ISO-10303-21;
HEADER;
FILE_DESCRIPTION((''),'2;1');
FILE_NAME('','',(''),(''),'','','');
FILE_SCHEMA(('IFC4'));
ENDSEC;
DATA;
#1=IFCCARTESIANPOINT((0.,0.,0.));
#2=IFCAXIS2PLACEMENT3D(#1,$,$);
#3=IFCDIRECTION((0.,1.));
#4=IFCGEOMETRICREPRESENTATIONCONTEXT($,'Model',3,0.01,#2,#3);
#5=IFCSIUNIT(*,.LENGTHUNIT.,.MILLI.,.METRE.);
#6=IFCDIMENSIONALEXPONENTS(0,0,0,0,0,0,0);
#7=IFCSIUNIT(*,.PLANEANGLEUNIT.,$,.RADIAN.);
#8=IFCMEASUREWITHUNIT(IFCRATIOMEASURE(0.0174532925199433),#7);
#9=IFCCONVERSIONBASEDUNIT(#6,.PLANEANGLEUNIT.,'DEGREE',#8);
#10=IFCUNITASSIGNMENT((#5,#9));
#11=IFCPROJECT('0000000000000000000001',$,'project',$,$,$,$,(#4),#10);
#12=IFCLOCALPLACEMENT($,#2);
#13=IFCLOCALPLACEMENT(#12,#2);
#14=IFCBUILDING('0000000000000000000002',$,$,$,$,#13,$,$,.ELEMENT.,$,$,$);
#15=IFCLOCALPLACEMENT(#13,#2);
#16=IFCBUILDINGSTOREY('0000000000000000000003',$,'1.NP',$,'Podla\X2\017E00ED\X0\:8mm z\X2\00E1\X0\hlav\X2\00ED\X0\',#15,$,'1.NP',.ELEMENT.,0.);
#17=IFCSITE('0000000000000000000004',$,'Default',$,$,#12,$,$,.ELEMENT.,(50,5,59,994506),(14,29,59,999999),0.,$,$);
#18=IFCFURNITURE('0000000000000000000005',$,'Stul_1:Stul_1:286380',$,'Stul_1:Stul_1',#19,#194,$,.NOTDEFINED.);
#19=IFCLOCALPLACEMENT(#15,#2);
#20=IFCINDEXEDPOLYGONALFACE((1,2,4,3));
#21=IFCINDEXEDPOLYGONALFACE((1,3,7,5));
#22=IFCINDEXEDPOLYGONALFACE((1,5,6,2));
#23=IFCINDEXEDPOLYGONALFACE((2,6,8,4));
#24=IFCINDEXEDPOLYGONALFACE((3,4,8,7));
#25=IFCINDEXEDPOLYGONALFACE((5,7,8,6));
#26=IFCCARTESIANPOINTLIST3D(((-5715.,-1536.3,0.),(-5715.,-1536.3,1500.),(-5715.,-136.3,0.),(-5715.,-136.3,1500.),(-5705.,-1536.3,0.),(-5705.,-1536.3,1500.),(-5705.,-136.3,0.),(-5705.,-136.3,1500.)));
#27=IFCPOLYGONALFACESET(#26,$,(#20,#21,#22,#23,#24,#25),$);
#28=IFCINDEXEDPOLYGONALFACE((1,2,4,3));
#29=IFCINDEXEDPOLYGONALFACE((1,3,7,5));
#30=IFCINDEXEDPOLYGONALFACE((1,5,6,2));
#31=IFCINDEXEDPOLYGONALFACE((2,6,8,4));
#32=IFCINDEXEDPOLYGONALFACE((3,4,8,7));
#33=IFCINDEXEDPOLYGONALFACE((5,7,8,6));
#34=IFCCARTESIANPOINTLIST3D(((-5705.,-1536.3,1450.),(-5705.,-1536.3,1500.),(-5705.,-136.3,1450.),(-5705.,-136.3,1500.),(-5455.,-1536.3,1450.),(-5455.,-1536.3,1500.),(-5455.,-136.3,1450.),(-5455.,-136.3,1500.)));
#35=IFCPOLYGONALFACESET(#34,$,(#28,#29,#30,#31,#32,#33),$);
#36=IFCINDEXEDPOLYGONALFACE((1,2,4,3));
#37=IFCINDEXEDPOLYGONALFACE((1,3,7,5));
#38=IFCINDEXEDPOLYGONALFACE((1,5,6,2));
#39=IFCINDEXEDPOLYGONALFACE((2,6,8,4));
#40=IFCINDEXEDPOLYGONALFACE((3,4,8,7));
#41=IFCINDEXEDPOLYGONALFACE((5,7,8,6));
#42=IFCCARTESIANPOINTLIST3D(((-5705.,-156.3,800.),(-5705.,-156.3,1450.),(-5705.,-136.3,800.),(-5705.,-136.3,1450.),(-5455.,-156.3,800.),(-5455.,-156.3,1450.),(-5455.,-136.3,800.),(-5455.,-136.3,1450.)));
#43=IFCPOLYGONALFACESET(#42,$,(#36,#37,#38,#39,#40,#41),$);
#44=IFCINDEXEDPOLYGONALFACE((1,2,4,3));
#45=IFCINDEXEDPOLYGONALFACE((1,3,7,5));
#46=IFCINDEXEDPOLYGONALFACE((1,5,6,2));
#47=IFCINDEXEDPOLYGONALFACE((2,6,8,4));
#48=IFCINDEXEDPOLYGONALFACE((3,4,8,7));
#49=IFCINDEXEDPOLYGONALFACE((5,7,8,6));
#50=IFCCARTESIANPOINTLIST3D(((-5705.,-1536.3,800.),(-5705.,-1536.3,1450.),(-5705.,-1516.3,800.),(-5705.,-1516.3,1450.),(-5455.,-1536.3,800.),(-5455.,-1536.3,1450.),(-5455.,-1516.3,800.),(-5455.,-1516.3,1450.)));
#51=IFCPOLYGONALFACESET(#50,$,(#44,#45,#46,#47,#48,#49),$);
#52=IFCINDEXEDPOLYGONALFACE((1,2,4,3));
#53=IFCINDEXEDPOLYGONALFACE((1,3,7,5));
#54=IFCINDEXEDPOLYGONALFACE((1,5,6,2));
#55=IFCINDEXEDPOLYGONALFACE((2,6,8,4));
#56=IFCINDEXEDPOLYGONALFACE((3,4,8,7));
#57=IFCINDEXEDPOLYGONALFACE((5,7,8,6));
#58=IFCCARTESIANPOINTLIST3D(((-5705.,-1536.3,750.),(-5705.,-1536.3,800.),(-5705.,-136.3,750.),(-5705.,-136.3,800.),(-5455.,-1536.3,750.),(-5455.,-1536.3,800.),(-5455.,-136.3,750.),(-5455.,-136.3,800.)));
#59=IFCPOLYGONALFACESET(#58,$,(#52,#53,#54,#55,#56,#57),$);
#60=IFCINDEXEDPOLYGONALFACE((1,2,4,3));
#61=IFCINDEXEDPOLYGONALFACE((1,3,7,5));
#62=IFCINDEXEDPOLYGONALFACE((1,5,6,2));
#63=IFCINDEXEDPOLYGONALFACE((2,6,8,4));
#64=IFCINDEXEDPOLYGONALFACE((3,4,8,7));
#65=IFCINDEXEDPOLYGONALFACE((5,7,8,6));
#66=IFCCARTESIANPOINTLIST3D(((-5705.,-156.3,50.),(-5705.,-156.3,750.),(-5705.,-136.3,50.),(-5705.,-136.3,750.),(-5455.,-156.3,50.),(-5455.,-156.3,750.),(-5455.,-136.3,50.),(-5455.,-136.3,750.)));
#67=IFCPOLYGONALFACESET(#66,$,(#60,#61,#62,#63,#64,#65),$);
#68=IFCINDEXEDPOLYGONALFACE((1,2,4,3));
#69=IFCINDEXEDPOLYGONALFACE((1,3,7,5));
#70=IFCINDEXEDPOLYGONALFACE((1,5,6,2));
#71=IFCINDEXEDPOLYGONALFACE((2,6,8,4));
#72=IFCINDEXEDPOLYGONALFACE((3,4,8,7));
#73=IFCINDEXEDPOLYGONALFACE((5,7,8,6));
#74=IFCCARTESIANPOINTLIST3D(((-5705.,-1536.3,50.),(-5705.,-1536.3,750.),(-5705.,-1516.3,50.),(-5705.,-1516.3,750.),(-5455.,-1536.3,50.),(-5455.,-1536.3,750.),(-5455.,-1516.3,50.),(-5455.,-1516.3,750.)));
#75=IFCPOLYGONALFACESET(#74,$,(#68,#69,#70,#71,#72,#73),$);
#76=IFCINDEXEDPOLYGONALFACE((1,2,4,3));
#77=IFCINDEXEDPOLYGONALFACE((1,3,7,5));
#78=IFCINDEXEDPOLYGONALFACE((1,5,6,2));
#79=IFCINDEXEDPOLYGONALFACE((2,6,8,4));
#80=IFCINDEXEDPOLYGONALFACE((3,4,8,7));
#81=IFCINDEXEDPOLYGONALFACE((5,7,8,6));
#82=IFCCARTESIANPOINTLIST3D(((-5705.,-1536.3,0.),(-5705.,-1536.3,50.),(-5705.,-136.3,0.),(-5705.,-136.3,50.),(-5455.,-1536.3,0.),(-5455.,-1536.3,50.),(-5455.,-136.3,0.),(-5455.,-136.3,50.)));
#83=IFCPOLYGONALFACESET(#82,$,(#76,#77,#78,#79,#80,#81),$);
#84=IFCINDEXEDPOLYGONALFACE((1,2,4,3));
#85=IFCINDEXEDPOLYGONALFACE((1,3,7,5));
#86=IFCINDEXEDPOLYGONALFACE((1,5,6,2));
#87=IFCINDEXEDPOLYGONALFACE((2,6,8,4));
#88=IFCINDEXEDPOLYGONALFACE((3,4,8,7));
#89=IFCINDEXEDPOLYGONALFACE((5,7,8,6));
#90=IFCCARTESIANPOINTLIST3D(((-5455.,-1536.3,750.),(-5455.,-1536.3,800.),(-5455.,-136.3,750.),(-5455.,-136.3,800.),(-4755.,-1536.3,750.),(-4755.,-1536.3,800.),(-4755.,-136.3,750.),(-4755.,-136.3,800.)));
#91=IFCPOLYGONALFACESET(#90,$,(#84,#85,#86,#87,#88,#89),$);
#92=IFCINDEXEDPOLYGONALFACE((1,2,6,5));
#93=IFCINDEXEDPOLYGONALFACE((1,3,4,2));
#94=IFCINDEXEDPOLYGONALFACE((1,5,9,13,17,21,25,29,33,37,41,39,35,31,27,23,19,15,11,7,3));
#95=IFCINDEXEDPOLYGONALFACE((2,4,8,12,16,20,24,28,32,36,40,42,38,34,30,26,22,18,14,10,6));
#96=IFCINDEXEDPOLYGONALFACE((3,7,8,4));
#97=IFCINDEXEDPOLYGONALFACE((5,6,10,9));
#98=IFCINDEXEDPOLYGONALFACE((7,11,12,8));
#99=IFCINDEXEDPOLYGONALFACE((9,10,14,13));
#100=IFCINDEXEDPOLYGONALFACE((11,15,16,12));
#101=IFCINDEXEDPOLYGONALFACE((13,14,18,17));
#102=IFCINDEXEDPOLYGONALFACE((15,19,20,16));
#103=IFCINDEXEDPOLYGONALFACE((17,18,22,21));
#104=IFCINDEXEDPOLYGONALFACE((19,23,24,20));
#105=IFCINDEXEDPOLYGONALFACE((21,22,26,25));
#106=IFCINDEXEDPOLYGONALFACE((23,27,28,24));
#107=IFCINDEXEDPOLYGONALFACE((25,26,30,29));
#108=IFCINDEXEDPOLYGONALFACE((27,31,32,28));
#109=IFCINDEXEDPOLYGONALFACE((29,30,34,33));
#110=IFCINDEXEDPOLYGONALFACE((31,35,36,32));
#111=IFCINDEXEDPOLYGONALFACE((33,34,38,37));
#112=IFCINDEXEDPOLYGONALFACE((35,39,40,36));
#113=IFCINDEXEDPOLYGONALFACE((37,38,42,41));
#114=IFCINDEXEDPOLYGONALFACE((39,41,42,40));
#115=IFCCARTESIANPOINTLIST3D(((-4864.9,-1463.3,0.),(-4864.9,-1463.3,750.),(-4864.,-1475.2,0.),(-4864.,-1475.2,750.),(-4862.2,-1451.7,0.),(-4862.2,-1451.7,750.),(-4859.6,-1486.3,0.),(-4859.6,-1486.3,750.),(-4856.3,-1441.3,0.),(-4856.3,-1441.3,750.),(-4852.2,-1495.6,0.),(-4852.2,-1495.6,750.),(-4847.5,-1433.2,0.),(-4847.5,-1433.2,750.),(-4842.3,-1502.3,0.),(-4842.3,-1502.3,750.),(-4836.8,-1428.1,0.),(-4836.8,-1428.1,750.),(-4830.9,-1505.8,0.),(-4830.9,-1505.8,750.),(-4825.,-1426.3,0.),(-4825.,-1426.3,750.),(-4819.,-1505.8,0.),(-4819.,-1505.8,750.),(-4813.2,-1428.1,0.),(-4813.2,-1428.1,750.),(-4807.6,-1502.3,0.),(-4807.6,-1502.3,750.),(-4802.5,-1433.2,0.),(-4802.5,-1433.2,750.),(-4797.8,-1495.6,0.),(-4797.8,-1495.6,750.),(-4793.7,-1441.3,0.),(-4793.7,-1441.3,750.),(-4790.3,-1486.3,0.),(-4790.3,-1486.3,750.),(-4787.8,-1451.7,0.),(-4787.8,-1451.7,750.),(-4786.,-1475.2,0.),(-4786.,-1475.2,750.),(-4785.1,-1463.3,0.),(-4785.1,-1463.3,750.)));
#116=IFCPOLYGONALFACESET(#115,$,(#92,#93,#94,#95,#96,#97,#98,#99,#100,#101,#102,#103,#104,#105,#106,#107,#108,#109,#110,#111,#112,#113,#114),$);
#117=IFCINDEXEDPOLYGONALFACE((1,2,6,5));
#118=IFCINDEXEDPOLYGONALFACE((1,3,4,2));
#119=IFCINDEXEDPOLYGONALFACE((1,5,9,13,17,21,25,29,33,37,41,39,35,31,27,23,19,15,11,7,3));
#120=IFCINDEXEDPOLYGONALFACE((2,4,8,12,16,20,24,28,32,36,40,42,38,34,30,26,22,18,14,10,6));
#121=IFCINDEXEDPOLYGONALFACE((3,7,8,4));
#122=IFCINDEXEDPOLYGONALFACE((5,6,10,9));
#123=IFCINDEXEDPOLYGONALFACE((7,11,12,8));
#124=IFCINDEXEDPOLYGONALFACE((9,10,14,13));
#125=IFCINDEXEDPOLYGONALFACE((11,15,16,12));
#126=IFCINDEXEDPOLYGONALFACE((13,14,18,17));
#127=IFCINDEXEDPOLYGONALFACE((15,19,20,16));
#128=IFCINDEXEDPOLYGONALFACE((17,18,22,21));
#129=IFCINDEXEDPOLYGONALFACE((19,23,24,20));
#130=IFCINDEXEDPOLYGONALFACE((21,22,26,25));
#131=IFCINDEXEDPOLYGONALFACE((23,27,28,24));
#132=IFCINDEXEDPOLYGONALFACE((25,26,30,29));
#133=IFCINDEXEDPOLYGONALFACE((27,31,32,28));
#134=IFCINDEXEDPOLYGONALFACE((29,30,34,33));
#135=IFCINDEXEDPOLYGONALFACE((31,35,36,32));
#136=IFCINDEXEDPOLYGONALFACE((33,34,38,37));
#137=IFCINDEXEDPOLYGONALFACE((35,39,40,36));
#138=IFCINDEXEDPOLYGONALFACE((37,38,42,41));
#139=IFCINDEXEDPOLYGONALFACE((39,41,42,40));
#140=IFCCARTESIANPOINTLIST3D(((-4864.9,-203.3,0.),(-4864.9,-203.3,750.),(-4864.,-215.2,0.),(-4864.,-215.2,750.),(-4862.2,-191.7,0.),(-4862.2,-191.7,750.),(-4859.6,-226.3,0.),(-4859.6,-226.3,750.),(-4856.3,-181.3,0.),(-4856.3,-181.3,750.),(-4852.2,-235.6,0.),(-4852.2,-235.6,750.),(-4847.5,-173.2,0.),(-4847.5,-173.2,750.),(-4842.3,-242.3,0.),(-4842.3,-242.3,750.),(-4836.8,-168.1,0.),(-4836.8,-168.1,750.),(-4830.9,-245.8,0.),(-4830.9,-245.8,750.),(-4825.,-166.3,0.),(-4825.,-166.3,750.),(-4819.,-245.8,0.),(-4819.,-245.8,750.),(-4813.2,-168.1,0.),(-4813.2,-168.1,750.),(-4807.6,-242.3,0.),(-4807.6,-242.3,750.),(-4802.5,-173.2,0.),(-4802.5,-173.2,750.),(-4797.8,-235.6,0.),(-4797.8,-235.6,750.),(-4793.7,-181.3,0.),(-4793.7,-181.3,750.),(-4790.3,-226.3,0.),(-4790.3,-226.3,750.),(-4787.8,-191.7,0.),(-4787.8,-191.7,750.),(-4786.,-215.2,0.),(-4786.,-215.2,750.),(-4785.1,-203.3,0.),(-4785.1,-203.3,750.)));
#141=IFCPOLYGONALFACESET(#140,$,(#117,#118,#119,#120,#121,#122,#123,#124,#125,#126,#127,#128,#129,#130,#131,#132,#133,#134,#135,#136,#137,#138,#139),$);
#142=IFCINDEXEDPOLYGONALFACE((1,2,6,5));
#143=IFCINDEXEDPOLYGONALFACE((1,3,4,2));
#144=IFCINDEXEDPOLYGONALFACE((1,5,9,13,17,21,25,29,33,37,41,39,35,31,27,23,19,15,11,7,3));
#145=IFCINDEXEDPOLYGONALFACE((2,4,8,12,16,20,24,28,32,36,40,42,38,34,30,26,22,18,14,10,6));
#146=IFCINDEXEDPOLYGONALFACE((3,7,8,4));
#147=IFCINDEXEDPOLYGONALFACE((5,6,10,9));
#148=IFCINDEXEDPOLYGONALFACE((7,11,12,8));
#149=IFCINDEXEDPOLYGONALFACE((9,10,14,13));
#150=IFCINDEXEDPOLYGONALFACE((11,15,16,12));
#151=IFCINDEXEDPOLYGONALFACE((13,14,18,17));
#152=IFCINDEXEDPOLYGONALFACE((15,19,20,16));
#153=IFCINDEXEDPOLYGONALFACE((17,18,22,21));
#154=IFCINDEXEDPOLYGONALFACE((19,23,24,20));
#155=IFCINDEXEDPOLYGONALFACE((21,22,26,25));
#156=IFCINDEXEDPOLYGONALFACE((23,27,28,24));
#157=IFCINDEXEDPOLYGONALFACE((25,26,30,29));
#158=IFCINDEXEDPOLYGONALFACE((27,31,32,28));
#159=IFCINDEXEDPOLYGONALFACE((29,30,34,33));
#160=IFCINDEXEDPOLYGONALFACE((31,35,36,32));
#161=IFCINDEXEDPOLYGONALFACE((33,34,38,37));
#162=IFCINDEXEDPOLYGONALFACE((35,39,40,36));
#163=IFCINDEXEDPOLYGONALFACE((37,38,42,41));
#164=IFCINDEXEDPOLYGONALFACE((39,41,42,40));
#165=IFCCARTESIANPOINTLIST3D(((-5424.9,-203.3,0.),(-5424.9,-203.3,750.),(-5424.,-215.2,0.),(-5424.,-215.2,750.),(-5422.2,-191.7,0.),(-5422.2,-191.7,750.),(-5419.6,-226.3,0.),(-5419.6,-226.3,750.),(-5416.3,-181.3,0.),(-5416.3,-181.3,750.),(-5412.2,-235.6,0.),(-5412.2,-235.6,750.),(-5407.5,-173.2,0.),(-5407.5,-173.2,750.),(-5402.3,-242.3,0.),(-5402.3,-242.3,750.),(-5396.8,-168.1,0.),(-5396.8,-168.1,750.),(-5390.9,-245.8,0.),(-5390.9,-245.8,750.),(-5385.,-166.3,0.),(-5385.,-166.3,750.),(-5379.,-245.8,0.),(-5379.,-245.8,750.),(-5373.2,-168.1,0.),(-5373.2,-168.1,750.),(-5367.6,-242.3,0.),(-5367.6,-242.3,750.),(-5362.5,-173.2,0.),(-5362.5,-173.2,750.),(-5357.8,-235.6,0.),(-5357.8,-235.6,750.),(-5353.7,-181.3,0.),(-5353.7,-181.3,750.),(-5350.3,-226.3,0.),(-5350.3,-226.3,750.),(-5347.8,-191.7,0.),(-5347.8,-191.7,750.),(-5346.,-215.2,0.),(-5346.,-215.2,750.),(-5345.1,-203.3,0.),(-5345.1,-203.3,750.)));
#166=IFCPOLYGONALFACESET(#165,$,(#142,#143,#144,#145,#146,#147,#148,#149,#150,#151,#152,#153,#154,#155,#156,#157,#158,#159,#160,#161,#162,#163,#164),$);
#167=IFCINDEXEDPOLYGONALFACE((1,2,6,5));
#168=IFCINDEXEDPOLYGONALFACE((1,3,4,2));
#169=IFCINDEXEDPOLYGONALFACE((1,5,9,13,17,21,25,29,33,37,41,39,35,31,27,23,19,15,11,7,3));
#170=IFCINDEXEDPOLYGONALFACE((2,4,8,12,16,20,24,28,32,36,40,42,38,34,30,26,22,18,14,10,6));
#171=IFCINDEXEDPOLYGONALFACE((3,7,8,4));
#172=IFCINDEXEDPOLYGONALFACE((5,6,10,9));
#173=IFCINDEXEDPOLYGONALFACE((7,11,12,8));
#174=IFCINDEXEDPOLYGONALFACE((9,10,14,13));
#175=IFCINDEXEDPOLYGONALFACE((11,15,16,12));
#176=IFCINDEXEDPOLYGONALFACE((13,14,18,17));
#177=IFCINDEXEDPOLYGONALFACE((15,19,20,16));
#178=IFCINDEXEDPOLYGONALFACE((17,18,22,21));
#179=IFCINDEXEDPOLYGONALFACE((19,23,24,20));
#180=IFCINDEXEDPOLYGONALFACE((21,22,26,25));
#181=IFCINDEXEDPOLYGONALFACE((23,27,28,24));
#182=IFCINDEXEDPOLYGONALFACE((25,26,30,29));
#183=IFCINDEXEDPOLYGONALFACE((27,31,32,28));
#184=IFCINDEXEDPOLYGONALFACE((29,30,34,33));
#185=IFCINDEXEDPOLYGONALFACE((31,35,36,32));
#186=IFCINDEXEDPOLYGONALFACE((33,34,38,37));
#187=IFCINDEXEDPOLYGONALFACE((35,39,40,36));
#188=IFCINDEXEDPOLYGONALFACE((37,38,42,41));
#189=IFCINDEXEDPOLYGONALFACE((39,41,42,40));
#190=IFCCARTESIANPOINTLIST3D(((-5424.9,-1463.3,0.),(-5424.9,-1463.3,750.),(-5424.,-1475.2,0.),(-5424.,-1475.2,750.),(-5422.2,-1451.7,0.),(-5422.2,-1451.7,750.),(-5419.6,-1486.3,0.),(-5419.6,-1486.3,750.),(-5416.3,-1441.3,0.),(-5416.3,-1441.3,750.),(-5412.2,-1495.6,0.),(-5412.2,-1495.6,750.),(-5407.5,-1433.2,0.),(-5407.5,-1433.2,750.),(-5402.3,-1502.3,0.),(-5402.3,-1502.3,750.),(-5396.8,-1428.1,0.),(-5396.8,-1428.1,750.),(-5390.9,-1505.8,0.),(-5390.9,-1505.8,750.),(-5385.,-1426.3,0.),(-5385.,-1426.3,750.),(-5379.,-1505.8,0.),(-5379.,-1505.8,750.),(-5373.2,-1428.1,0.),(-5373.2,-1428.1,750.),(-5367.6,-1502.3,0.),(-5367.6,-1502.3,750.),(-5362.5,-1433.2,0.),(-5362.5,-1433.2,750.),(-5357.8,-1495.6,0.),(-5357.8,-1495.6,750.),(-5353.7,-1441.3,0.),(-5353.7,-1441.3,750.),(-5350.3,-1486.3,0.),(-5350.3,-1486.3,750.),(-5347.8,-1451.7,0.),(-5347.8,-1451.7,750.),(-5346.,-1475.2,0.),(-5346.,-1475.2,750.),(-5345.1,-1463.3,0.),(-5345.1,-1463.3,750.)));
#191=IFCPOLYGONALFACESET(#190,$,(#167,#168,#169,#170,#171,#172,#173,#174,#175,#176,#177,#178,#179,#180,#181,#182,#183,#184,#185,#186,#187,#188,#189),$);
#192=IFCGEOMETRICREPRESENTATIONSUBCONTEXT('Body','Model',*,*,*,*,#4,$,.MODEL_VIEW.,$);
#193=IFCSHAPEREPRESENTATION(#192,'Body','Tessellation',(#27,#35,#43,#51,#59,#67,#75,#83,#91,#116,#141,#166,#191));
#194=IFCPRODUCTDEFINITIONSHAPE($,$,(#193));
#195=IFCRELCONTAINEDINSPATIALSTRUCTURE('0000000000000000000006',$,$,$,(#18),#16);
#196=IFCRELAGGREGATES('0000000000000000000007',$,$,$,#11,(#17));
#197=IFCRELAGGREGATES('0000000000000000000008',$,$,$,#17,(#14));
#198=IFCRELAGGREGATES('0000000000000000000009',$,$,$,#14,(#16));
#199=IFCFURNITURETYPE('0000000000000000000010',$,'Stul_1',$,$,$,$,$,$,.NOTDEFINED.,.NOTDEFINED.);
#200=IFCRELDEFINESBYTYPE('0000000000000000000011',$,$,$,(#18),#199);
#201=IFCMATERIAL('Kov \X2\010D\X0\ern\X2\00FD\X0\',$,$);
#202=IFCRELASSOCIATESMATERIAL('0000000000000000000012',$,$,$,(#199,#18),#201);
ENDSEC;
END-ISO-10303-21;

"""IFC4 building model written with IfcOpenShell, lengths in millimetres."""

from ifc_helpers import new_model, entity, si_unit, converted_unit, direction, frame, frame_2d, origin, origin_2d_with_axis, place, context, subcontext, project, spatial, rectangle, circle, extrude, source, transform, mapped, material, type_object, type_shapes, element, save


model = new_model("IFC4")

# Units and contexts
model_context = context("Model", 3, precision=0.01, world=origin(), true_north=direction((0.0, 1.0)))
body_context = subcontext(model_context, "Body", "Model", "MODEL_VIEW")
ifc_project = project(units=[si_unit("LENGTHUNIT", "METRE", prefix="MILLI"), converted_unit("PLANEANGLEUNIT", "DEGREE", entity("IfcRatioMeasure", 0.0174532925199433), si_unit("PLANEANGLEUNIT", "RADIAN"), dimensions=[0, 0, 0, 0, 0, 0, 0])], contexts=[model_context])

# Site, building, storey
site_placement = place(None, origin())
site = spatial("IfcSite", under=ifc_project, at=site_placement, Name="Default", CompositionType="ELEMENT", RefLatitude=(50, 5, 59, 994506), RefLongitude=(14, 29, 59, 999999), RefElevation=0.0)
building_placement = place(site_placement, origin())
building = spatial("IfcBuilding", under=site, at=building_placement, CompositionType="ELEMENT")
storey_placement = place(building_placement, origin())
storey = spatial("IfcBuildingStorey", under=building, at=storey_placement, Name="1.NP", ObjectType="Podlaží:8mm záhlaví", LongName="1.NP", CompositionType="ELEMENT", Elevation=0.0)

# Furniture
ifc_material_1 = material(Name="Kov černý")
furniture_type = type_object("IfcFurnitureType", Name="Stul_1", AssemblyPlace="NOTDEFINED", PredefinedType="NOTDEFINED", material=ifc_material_1)
shared_shape_1 = source(origin(), body_context, "Body", "SweptSolid", [
    extrude(rectangle(XDim=1400.0, YDim=10.0, at=origin_2d_with_axis()), frame((0.0, 605.0, 0.0), z_axis=(0.0, 0.0, 1.0), x_axis=(-1.0, 0.0, 0.0)), (0.0, 0.0, 1.0), 1500.0),
    extrude(rectangle(XDim=1400.0, YDim=250.0, at=frame_2d((0.0, 0.0), x_axis=(1.0, 0.0))), frame((0.0, 475.0, 1450.0), z_axis=(0.0, 0.0, 1.0), x_axis=(-1.0, 0.0, 0.0)), (0.0, 0.0, 1.0), 50.0),
    extrude(rectangle(XDim=20.0, YDim=250.0, at=origin_2d_with_axis()), frame((690.0, 475.0, 800.0), z_axis=(0.0, 0.0, 1.0), x_axis=(-1.0, 0.0, 0.0)), (0.0, 0.0, 1.0), 650.0),
    extrude(rectangle(XDim=20.0, YDim=250.0, at=frame_2d((0.0, 0.0), x_axis=(1.0, 0.0))), frame((-690.0, 475.0, 800.0), z_axis=(0.0, 0.0, 1.0), x_axis=(-1.0, 0.0, 0.0)), (0.0, 0.0, 1.0), 650.0),
    extrude(rectangle(XDim=1400.0, YDim=250.0, at=origin_2d_with_axis()), frame((0.0, 475.0, 750.0), z_axis=(0.0, 0.0, 1.0), x_axis=(-1.0, 0.0, 0.0)), (0.0, 0.0, 1.0), 50.0),
    extrude(rectangle(XDim=20.0, YDim=250.0, at=origin_2d_with_axis()), frame((690.0, 475.0, 50.0), z_axis=(0.0, 0.0, 1.0), x_axis=(-1.0, 0.0, 0.0)), (0.0, 0.0, 1.0), 700.0),
    extrude(rectangle(XDim=20.0, YDim=250.0, at=frame_2d((0.0, 0.0), x_axis=(1.0, 0.0))), frame((-690.0, 475.0, 50.0), z_axis=(0.0, 0.0, 1.0), x_axis=(-1.0, 0.0, 0.0)), (0.0, 0.0, 1.0), 700.0),
    extrude(rectangle(XDim=1400.0, YDim=250.0, at=origin_2d_with_axis()), frame((0.0, 475.0, 0.0), z_axis=(0.0, 0.0, 1.0), x_axis=(-1.0, 0.0, 0.0)), (0.0, 0.0, 1.0), 50.0),
    extrude(rectangle(XDim=1400.0, YDim=700.0, at=origin_2d_with_axis()), frame((0.0, 0.0, 750.0), z_axis=(0.0, 0.0, 1.0), x_axis=(-1.0, 0.0, 0.0)), (0.0, 0.0, 1.0), 50.0),
    extrude(circle(Radius=40.0, at=frame_2d((0.0, 0.0), x_axis=(1.0, 0.0))), frame((-630.0, -280.0, 0.0)), (0.0, 0.0, 1.0), 750.0),
    extrude(circle(Radius=40.0, at=frame_2d((0.0, 0.0), x_axis=(1.0, 0.0))), frame((630.0, -280.0, 0.0)), (0.0, 0.0, 1.0), 750.0),
    extrude(circle(Radius=40.0, at=frame_2d((0.0, 0.0), x_axis=(1.0, 0.0))), frame((630.0, 280.0, 0.0)), (0.0, 0.0, 1.0), 750.0),
    extrude(circle(Radius=40.0, at=frame_2d((0.0, 0.0), x_axis=(1.0, 0.0))), frame((-630.0, 280.0, 0.0)), (0.0, 0.0, 1.0), 750.0),
])
type_shapes(furniture_type, [shared_shape_1])
for number, where, z_axis, x_axis, name in (
    (1, (-5105.0, -836.3, 0.0), (0.0, 0.0, 1.0), (0.0, 1.0, 0.0), "Stul_1:Stul_1:286380"),
):
    element("IfcFurniture", number, at=place(storey_placement, frame(where, z_axis=z_axis, x_axis=x_axis)), inside=storey, type_object=furniture_type, material=ifc_material_1, Name=name, ObjectType="Stul_1:Stul_1", PredefinedType="NOTDEFINED", context=body_context, shape_type="MappedRepresentation", body=[
        mapped(shared_shape_1, transform((0.0, 0.0, 0.0), scale=1.0)),
    ])

save(model, "model.ifc")
